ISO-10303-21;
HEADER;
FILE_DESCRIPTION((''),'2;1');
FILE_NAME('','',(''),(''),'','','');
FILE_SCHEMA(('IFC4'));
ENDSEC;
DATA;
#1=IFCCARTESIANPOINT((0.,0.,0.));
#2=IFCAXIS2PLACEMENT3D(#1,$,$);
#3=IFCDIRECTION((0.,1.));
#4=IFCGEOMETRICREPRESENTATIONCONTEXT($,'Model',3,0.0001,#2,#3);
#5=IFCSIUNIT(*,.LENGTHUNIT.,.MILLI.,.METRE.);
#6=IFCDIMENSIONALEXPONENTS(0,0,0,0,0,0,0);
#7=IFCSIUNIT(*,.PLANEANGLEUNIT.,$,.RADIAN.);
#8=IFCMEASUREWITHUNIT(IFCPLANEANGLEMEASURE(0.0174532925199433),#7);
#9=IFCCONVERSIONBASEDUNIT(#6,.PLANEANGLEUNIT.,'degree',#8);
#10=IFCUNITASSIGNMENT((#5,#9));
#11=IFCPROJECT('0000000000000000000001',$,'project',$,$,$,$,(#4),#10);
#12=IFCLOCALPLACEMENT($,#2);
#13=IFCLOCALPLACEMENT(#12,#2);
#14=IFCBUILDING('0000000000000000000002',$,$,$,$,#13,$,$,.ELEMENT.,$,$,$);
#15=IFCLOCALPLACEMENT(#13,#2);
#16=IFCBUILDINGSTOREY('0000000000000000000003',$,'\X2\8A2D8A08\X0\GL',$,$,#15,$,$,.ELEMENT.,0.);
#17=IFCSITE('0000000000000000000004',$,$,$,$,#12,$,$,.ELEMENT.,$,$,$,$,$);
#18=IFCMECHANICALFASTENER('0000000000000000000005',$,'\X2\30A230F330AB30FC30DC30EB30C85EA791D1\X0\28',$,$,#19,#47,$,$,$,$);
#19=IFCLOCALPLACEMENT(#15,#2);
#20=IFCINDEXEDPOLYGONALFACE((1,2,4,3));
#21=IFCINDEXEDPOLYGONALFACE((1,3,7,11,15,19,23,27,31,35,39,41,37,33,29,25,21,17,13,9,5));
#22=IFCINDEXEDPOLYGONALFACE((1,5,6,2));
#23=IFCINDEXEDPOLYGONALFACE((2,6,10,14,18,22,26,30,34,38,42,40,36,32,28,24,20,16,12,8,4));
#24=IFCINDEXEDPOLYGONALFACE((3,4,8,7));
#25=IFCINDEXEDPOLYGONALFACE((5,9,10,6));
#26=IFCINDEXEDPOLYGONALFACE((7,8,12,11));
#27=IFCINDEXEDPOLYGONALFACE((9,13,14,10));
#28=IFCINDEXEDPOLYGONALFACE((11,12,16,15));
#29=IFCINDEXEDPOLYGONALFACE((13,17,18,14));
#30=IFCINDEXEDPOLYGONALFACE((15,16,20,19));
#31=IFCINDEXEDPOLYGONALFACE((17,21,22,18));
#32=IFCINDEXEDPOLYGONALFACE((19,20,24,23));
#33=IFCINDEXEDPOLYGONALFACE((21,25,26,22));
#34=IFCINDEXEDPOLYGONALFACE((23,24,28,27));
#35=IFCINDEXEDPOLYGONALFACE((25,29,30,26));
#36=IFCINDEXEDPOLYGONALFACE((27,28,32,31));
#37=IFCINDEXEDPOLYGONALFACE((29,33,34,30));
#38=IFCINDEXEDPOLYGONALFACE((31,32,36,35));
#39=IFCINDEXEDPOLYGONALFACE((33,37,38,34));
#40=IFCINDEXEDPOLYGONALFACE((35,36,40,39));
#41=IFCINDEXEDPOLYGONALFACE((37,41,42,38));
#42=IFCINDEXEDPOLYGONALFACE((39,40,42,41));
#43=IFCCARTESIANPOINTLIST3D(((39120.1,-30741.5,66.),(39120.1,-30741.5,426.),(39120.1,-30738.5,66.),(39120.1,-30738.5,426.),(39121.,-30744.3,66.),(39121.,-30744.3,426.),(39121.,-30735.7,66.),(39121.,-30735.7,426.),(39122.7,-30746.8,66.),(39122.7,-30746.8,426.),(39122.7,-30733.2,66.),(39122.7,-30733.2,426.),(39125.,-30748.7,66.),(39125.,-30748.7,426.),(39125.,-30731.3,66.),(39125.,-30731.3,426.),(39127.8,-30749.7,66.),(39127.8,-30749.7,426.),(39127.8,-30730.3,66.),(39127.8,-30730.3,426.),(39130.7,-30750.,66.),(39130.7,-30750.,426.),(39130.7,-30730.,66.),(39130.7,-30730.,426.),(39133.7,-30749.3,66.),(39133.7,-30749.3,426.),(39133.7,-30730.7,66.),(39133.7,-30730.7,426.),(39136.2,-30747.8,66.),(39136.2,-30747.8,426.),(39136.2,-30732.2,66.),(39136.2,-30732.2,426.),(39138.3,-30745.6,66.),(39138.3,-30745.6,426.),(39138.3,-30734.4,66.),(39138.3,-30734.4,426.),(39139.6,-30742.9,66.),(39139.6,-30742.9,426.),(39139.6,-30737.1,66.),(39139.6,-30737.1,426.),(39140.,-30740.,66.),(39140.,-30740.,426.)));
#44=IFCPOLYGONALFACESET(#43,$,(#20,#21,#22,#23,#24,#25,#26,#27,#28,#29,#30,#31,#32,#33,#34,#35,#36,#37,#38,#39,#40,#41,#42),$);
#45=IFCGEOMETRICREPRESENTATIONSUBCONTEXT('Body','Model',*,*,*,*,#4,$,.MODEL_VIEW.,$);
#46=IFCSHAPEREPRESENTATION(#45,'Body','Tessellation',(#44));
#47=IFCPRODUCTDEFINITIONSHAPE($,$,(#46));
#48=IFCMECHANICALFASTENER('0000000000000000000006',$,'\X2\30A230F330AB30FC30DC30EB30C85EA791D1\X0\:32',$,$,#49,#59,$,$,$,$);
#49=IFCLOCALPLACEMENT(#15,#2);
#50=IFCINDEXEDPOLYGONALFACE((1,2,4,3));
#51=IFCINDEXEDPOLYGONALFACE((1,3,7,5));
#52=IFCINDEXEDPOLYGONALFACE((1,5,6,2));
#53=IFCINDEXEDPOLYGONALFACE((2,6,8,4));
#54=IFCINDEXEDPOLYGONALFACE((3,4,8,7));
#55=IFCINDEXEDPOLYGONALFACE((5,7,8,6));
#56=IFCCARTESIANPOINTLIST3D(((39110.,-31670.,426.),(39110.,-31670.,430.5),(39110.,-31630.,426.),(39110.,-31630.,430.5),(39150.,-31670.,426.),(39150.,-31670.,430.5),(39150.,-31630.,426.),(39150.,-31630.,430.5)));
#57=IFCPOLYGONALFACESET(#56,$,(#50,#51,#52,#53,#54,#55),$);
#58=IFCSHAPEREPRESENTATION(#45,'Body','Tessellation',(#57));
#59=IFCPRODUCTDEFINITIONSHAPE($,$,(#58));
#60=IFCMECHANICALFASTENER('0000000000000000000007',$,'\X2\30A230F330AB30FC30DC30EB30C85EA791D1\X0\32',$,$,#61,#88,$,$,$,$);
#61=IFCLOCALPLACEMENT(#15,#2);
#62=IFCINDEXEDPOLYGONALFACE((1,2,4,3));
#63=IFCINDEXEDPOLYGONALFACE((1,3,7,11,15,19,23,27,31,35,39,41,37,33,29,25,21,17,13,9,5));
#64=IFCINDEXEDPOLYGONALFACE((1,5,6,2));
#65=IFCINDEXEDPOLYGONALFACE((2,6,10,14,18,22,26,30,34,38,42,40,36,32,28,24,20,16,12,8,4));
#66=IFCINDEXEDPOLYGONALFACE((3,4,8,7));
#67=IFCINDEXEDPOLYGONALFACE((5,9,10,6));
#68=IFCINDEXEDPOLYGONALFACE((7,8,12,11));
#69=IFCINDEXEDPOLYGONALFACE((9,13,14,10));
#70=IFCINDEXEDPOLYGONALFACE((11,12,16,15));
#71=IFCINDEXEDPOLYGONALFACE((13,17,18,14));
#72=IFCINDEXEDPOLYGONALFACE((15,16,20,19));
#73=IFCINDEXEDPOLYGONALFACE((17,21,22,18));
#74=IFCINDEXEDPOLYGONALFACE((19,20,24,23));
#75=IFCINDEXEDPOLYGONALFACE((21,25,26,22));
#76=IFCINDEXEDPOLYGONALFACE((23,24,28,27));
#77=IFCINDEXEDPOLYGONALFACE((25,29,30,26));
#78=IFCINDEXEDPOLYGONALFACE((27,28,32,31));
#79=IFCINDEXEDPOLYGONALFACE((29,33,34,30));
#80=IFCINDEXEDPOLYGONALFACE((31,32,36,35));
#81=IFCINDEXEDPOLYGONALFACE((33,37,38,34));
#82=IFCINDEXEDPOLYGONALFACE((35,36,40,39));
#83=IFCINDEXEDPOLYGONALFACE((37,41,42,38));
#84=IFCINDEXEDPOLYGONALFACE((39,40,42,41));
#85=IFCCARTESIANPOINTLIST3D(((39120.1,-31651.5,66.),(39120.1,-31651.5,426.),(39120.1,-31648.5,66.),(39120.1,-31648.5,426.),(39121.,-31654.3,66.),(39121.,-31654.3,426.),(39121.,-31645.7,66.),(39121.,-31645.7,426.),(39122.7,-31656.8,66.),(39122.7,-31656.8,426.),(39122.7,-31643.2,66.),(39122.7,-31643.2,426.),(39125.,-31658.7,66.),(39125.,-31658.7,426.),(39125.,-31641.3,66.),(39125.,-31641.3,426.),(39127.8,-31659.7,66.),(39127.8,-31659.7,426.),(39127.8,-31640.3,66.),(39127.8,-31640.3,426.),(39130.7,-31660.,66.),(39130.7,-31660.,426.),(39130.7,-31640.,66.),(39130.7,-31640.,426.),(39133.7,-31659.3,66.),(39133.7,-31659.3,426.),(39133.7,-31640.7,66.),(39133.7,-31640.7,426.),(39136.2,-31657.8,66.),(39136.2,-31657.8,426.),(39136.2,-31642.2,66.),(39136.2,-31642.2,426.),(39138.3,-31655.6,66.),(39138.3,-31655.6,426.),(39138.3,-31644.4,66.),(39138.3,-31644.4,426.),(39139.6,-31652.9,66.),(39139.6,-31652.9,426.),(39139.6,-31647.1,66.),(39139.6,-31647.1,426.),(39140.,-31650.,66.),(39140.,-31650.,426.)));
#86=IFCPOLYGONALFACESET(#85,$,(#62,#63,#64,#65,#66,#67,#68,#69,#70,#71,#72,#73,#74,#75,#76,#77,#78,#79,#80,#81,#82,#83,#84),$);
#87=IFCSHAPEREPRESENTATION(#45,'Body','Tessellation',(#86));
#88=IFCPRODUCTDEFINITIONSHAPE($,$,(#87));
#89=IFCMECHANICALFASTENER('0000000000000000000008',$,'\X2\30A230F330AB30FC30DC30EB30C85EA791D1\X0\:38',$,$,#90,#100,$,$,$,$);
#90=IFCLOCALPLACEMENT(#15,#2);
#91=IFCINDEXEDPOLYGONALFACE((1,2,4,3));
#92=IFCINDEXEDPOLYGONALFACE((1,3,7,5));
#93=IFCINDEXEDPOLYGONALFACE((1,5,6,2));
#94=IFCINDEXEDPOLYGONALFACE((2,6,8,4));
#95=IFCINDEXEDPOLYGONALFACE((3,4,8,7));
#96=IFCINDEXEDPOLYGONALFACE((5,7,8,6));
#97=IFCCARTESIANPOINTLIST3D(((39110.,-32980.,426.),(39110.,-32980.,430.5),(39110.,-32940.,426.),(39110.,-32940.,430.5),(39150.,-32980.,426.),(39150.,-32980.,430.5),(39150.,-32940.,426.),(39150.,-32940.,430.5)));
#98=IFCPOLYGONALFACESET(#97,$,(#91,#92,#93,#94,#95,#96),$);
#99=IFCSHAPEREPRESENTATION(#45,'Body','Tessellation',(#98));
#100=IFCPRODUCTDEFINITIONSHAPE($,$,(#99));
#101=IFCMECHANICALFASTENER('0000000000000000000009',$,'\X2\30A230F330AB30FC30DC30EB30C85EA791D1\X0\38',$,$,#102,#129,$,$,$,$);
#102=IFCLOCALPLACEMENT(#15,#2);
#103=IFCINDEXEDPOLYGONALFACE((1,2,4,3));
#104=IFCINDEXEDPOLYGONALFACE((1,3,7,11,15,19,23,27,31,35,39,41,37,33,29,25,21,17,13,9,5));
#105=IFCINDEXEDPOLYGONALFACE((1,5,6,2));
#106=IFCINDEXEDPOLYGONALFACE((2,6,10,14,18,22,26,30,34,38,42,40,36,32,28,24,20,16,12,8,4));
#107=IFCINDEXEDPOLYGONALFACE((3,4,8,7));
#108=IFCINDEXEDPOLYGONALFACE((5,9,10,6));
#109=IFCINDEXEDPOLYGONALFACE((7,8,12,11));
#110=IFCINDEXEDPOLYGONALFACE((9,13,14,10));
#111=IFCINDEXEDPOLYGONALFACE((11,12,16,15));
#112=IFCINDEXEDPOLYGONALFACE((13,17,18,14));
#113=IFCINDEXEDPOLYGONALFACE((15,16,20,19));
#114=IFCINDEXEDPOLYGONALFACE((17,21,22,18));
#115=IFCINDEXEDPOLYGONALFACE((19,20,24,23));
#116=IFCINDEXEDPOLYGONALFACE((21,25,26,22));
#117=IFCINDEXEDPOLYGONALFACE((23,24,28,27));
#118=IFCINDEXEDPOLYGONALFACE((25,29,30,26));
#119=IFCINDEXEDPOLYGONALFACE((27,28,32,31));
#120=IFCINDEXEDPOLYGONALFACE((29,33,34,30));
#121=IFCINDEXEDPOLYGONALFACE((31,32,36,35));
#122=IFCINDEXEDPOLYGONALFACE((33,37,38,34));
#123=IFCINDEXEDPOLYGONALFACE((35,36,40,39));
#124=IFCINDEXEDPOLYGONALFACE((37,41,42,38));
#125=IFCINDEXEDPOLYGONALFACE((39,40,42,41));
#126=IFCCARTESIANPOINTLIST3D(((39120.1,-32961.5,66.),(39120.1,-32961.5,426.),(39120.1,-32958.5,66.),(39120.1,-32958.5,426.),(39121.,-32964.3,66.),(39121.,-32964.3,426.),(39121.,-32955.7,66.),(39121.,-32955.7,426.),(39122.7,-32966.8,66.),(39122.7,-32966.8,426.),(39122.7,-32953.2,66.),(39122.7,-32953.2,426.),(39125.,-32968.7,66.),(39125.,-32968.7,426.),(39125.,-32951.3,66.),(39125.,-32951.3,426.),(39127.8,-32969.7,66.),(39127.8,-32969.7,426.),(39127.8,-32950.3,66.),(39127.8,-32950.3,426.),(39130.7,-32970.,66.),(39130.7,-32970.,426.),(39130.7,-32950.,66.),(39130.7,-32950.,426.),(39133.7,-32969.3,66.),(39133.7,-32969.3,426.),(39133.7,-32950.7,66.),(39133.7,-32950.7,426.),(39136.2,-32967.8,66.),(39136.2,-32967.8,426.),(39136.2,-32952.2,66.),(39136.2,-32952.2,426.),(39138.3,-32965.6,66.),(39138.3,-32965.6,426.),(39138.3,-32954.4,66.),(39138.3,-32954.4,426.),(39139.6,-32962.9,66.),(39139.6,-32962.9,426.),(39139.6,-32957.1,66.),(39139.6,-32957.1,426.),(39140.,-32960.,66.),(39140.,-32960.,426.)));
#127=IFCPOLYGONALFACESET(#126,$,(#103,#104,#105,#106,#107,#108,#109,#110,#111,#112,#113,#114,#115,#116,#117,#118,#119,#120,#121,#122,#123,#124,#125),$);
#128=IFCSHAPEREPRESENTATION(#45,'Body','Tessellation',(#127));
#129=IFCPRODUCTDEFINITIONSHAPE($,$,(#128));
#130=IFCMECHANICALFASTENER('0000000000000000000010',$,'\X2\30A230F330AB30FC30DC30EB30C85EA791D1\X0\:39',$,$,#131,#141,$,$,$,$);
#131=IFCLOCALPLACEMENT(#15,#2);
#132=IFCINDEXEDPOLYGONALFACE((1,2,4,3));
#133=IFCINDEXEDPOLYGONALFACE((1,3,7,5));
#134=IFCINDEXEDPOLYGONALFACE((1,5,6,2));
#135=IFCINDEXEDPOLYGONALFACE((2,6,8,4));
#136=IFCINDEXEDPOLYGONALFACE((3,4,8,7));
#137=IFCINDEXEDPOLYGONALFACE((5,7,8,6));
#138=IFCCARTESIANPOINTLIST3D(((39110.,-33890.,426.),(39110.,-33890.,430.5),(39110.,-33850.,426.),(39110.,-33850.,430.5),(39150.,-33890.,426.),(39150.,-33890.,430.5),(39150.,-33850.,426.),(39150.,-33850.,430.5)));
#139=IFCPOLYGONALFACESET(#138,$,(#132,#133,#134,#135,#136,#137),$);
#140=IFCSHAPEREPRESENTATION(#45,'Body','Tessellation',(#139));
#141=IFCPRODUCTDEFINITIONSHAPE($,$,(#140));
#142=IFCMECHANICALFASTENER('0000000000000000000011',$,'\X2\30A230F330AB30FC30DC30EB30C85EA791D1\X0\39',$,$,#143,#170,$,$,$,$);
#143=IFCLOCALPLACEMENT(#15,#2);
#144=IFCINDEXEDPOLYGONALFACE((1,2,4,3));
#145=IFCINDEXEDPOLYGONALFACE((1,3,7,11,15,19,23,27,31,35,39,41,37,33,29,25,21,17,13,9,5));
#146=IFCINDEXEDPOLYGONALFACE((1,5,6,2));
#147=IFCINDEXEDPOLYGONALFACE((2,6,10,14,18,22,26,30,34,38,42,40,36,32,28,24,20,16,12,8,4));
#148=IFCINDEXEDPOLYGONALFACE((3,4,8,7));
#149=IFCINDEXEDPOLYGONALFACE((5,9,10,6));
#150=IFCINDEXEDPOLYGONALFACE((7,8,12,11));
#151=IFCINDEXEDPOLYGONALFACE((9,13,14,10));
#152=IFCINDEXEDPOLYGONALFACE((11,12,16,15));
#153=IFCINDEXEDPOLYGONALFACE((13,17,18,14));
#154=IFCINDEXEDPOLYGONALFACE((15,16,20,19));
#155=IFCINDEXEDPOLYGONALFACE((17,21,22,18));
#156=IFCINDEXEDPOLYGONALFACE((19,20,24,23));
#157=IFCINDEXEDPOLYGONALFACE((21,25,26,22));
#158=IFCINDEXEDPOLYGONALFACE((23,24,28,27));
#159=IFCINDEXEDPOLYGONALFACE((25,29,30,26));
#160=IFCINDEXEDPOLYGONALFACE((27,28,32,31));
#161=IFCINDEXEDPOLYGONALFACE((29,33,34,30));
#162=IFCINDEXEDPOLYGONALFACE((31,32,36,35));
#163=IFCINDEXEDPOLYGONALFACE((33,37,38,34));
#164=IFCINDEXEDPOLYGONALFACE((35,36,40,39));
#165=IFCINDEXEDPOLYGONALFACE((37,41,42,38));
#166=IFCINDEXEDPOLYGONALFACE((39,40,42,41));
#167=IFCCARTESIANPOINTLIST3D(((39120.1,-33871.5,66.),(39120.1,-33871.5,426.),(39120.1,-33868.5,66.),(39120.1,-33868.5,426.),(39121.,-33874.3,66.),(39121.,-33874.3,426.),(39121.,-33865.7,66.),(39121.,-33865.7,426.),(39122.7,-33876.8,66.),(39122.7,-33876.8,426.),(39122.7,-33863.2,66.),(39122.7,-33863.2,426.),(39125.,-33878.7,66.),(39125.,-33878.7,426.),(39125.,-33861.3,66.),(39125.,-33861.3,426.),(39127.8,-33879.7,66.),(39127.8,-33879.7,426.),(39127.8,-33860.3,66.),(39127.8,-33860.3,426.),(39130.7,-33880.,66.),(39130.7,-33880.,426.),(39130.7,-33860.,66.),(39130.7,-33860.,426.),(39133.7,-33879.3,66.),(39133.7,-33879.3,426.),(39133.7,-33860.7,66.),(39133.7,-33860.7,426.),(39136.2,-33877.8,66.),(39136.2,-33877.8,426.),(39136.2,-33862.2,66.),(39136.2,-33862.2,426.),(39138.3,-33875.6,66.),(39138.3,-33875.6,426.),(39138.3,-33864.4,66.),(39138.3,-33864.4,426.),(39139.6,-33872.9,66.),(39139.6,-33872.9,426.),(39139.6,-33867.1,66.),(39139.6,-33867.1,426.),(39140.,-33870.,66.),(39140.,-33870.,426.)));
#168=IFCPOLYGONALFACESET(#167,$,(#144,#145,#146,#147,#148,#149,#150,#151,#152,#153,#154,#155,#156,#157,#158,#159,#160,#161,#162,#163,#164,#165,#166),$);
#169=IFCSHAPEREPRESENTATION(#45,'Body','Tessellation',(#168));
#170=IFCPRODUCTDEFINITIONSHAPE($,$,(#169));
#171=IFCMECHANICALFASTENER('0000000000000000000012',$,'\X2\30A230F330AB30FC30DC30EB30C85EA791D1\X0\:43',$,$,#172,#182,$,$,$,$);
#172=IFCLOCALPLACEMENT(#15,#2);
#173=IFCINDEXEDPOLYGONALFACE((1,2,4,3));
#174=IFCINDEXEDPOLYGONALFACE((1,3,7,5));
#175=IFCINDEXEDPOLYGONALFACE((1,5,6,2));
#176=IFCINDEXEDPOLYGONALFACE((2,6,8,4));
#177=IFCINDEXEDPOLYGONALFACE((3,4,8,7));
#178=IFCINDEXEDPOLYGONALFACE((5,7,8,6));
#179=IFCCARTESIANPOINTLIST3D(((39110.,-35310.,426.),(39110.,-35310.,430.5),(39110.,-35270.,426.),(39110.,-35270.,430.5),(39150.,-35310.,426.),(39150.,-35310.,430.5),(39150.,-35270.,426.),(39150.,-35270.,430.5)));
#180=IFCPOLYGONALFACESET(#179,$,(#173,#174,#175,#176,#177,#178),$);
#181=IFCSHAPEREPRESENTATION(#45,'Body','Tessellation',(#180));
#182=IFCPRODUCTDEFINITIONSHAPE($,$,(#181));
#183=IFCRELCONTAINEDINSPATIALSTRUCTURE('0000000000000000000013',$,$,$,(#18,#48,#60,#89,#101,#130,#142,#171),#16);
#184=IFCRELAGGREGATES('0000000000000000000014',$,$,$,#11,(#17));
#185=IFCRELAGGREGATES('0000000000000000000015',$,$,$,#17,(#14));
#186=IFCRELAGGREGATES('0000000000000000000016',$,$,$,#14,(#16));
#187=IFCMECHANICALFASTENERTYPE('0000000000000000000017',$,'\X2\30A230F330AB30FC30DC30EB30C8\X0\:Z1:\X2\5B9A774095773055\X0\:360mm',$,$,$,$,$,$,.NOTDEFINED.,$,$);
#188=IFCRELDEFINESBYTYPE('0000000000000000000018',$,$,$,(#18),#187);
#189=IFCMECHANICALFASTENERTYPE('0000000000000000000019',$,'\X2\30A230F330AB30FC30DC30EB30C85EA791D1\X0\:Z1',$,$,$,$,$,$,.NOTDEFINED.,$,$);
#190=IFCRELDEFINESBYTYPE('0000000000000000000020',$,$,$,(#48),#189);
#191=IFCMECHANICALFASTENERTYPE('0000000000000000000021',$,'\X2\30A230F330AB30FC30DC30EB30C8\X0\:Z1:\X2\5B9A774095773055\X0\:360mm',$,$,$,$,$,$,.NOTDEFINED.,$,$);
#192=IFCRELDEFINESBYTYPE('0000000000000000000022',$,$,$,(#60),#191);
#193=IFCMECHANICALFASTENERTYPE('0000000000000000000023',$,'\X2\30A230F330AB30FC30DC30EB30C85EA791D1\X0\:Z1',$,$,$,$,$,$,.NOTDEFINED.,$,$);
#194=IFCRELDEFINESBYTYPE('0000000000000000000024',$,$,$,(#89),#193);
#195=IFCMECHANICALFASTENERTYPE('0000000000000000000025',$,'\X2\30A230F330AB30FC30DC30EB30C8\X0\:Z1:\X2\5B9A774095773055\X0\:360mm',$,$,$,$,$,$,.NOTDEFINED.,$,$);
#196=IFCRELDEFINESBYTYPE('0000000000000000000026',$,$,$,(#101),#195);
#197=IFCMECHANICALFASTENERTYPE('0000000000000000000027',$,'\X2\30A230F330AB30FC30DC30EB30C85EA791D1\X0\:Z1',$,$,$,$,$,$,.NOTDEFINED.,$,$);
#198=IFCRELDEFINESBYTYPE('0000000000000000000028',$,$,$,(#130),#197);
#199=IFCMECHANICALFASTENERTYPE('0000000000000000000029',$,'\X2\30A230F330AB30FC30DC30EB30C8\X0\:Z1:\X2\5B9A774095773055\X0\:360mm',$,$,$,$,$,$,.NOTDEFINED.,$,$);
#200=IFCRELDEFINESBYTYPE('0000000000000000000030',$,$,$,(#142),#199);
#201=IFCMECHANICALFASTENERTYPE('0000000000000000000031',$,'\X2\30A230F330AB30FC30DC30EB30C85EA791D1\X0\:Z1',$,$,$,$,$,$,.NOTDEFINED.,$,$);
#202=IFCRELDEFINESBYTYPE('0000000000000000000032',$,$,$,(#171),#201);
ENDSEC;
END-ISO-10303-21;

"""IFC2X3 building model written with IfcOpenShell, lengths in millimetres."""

from ifc_helpers import new_model, entity, si_unit, converted_unit, direction, frame, origin, origin_with_axes, origin_2d, place, context, subcontext, project, spatial, rectangle, circle, extrude, type_object, element, save


model = new_model("IFC2X3")

# Units and contexts
model_context = context("Model", 3, precision=0.0001, world=origin(), true_north=direction((0.0, 1.0)))
body_context = subcontext(model_context, "Body", "Model", "MODEL_VIEW")
ifc_project = project(units=[si_unit("LENGTHUNIT", "METRE", prefix="MILLI"), converted_unit("PLANEANGLEUNIT", "degree", entity("IfcPlaneAngleMeasure", 0.0174532925199433), si_unit("PLANEANGLEUNIT", "RADIAN"), dimensions=[0, 0, 0, 0, 0, 0, 0])], contexts=[model_context])

# Site, building, storey
site_placement = place(None, origin())
site = spatial("IfcSite", under=ifc_project, at=site_placement, CompositionType="ELEMENT")
building_placement = place(site_placement, origin())
building = spatial("IfcBuilding", under=site, at=building_placement, CompositionType="ELEMENT")
storey_placement = place(building_placement, origin())
storey = spatial("IfcBuildingStorey", under=building, at=storey_placement, Name="設計GL", CompositionType="ELEMENT", Elevation=0.0)

# Mechanical fasteners
mechanical_fastener_type_1 = type_object("IfcMechanicalFastenerType", Name="アンカーボルト:Z1:定着長さ:360mm")
mechanical_fastener_1_placement = place(storey_placement, frame((39130.0, -30740.0, 66.0)))
element("IfcMechanicalFastener", 1, at=mechanical_fastener_1_placement, inside=storey, type_object=mechanical_fastener_type_1, Name="アンカーボルト座金28", context=body_context, shape_type="SweptSolid", body=[
    extrude(circle(Radius=10.0, at=origin_2d()), origin_with_axes(), (0.0, 0.0, 1.0), 360.0),
])
mechanical_fastener_type_2 = type_object("IfcMechanicalFastenerType", Name="アンカーボルト座金:Z1")
mechanical_fastener_2_placement = place(storey_placement, frame((39130.0, -31650.0, 426.0)))
element("IfcMechanicalFastener", 2, at=mechanical_fastener_2_placement, inside=storey, type_object=mechanical_fastener_type_2, Name="アンカーボルト座金:32", context=body_context, shape_type="SweptSolid", body=[
    extrude(rectangle(XDim=40.0, YDim=40.0, at=origin_2d()), origin_with_axes(), (0.0, 0.0, 1.0), 4.5),
])
mechanical_fastener_type_3 = type_object("IfcMechanicalFastenerType", Name="アンカーボルト:Z1:定着長さ:360mm")
mechanical_fastener_3_placement = place(storey_placement, frame((39130.0, -31650.0, 66.0)))
element("IfcMechanicalFastener", 3, at=mechanical_fastener_3_placement, inside=storey, type_object=mechanical_fastener_type_3, Name="アンカーボルト座金32", context=body_context, shape_type="SweptSolid", body=[
    extrude(circle(Radius=10.0, at=origin_2d()), origin_with_axes(), (0.0, 0.0, 1.0), 360.0),
])
mechanical_fastener_type_4 = type_object("IfcMechanicalFastenerType", Name="アンカーボルト座金:Z1")
mechanical_fastener_4_placement = place(storey_placement, frame((39130.0, -32960.0, 426.0)))
element("IfcMechanicalFastener", 4, at=mechanical_fastener_4_placement, inside=storey, type_object=mechanical_fastener_type_4, Name="アンカーボルト座金:38", context=body_context, shape_type="SweptSolid", body=[
    extrude(rectangle(XDim=40.0, YDim=40.0, at=origin_2d()), origin_with_axes(), (0.0, 0.0, 1.0), 4.5),
])
mechanical_fastener_type_5 = type_object("IfcMechanicalFastenerType", Name="アンカーボルト:Z1:定着長さ:360mm")
mechanical_fastener_5_placement = place(storey_placement, frame((39130.0, -32960.0, 66.0)))
element("IfcMechanicalFastener", 5, at=mechanical_fastener_5_placement, inside=storey, type_object=mechanical_fastener_type_5, Name="アンカーボルト座金38", context=body_context, shape_type="SweptSolid", body=[
    extrude(circle(Radius=10.0, at=origin_2d()), origin_with_axes(), (0.0, 0.0, 1.0), 360.0),
])
mechanical_fastener_type_6 = type_object("IfcMechanicalFastenerType", Name="アンカーボルト座金:Z1")
mechanical_fastener_6_placement = place(storey_placement, frame((39130.0, -33870.0, 426.0)))
element("IfcMechanicalFastener", 6, at=mechanical_fastener_6_placement, inside=storey, type_object=mechanical_fastener_type_6, Name="アンカーボルト座金:39", context=body_context, shape_type="SweptSolid", body=[
    extrude(rectangle(XDim=40.0, YDim=40.0, at=origin_2d()), origin_with_axes(), (0.0, 0.0, 1.0), 4.5),
])
mechanical_fastener_type_7 = type_object("IfcMechanicalFastenerType", Name="アンカーボルト:Z1:定着長さ:360mm")
mechanical_fastener_7_placement = place(storey_placement, frame((39130.0, -33870.0, 66.0)))
element("IfcMechanicalFastener", 7, at=mechanical_fastener_7_placement, inside=storey, type_object=mechanical_fastener_type_7, Name="アンカーボルト座金39", context=body_context, shape_type="SweptSolid", body=[
    extrude(circle(Radius=10.0, at=origin_2d()), origin_with_axes(), (0.0, 0.0, 1.0), 360.0),
])
mechanical_fastener_type_8 = type_object("IfcMechanicalFastenerType", Name="アンカーボルト座金:Z1")
mechanical_fastener_8_placement = place(storey_placement, frame((39130.0, -35290.0, 426.0)))
element("IfcMechanicalFastener", 8, at=mechanical_fastener_8_placement, inside=storey, type_object=mechanical_fastener_type_8, Name="アンカーボルト座金:43", context=body_context, shape_type="SweptSolid", body=[
    extrude(rectangle(XDim=40.0, YDim=40.0, at=origin_2d()), origin_with_axes(), (0.0, 0.0, 1.0), 4.5),
])

save(model, "model.ifc")
